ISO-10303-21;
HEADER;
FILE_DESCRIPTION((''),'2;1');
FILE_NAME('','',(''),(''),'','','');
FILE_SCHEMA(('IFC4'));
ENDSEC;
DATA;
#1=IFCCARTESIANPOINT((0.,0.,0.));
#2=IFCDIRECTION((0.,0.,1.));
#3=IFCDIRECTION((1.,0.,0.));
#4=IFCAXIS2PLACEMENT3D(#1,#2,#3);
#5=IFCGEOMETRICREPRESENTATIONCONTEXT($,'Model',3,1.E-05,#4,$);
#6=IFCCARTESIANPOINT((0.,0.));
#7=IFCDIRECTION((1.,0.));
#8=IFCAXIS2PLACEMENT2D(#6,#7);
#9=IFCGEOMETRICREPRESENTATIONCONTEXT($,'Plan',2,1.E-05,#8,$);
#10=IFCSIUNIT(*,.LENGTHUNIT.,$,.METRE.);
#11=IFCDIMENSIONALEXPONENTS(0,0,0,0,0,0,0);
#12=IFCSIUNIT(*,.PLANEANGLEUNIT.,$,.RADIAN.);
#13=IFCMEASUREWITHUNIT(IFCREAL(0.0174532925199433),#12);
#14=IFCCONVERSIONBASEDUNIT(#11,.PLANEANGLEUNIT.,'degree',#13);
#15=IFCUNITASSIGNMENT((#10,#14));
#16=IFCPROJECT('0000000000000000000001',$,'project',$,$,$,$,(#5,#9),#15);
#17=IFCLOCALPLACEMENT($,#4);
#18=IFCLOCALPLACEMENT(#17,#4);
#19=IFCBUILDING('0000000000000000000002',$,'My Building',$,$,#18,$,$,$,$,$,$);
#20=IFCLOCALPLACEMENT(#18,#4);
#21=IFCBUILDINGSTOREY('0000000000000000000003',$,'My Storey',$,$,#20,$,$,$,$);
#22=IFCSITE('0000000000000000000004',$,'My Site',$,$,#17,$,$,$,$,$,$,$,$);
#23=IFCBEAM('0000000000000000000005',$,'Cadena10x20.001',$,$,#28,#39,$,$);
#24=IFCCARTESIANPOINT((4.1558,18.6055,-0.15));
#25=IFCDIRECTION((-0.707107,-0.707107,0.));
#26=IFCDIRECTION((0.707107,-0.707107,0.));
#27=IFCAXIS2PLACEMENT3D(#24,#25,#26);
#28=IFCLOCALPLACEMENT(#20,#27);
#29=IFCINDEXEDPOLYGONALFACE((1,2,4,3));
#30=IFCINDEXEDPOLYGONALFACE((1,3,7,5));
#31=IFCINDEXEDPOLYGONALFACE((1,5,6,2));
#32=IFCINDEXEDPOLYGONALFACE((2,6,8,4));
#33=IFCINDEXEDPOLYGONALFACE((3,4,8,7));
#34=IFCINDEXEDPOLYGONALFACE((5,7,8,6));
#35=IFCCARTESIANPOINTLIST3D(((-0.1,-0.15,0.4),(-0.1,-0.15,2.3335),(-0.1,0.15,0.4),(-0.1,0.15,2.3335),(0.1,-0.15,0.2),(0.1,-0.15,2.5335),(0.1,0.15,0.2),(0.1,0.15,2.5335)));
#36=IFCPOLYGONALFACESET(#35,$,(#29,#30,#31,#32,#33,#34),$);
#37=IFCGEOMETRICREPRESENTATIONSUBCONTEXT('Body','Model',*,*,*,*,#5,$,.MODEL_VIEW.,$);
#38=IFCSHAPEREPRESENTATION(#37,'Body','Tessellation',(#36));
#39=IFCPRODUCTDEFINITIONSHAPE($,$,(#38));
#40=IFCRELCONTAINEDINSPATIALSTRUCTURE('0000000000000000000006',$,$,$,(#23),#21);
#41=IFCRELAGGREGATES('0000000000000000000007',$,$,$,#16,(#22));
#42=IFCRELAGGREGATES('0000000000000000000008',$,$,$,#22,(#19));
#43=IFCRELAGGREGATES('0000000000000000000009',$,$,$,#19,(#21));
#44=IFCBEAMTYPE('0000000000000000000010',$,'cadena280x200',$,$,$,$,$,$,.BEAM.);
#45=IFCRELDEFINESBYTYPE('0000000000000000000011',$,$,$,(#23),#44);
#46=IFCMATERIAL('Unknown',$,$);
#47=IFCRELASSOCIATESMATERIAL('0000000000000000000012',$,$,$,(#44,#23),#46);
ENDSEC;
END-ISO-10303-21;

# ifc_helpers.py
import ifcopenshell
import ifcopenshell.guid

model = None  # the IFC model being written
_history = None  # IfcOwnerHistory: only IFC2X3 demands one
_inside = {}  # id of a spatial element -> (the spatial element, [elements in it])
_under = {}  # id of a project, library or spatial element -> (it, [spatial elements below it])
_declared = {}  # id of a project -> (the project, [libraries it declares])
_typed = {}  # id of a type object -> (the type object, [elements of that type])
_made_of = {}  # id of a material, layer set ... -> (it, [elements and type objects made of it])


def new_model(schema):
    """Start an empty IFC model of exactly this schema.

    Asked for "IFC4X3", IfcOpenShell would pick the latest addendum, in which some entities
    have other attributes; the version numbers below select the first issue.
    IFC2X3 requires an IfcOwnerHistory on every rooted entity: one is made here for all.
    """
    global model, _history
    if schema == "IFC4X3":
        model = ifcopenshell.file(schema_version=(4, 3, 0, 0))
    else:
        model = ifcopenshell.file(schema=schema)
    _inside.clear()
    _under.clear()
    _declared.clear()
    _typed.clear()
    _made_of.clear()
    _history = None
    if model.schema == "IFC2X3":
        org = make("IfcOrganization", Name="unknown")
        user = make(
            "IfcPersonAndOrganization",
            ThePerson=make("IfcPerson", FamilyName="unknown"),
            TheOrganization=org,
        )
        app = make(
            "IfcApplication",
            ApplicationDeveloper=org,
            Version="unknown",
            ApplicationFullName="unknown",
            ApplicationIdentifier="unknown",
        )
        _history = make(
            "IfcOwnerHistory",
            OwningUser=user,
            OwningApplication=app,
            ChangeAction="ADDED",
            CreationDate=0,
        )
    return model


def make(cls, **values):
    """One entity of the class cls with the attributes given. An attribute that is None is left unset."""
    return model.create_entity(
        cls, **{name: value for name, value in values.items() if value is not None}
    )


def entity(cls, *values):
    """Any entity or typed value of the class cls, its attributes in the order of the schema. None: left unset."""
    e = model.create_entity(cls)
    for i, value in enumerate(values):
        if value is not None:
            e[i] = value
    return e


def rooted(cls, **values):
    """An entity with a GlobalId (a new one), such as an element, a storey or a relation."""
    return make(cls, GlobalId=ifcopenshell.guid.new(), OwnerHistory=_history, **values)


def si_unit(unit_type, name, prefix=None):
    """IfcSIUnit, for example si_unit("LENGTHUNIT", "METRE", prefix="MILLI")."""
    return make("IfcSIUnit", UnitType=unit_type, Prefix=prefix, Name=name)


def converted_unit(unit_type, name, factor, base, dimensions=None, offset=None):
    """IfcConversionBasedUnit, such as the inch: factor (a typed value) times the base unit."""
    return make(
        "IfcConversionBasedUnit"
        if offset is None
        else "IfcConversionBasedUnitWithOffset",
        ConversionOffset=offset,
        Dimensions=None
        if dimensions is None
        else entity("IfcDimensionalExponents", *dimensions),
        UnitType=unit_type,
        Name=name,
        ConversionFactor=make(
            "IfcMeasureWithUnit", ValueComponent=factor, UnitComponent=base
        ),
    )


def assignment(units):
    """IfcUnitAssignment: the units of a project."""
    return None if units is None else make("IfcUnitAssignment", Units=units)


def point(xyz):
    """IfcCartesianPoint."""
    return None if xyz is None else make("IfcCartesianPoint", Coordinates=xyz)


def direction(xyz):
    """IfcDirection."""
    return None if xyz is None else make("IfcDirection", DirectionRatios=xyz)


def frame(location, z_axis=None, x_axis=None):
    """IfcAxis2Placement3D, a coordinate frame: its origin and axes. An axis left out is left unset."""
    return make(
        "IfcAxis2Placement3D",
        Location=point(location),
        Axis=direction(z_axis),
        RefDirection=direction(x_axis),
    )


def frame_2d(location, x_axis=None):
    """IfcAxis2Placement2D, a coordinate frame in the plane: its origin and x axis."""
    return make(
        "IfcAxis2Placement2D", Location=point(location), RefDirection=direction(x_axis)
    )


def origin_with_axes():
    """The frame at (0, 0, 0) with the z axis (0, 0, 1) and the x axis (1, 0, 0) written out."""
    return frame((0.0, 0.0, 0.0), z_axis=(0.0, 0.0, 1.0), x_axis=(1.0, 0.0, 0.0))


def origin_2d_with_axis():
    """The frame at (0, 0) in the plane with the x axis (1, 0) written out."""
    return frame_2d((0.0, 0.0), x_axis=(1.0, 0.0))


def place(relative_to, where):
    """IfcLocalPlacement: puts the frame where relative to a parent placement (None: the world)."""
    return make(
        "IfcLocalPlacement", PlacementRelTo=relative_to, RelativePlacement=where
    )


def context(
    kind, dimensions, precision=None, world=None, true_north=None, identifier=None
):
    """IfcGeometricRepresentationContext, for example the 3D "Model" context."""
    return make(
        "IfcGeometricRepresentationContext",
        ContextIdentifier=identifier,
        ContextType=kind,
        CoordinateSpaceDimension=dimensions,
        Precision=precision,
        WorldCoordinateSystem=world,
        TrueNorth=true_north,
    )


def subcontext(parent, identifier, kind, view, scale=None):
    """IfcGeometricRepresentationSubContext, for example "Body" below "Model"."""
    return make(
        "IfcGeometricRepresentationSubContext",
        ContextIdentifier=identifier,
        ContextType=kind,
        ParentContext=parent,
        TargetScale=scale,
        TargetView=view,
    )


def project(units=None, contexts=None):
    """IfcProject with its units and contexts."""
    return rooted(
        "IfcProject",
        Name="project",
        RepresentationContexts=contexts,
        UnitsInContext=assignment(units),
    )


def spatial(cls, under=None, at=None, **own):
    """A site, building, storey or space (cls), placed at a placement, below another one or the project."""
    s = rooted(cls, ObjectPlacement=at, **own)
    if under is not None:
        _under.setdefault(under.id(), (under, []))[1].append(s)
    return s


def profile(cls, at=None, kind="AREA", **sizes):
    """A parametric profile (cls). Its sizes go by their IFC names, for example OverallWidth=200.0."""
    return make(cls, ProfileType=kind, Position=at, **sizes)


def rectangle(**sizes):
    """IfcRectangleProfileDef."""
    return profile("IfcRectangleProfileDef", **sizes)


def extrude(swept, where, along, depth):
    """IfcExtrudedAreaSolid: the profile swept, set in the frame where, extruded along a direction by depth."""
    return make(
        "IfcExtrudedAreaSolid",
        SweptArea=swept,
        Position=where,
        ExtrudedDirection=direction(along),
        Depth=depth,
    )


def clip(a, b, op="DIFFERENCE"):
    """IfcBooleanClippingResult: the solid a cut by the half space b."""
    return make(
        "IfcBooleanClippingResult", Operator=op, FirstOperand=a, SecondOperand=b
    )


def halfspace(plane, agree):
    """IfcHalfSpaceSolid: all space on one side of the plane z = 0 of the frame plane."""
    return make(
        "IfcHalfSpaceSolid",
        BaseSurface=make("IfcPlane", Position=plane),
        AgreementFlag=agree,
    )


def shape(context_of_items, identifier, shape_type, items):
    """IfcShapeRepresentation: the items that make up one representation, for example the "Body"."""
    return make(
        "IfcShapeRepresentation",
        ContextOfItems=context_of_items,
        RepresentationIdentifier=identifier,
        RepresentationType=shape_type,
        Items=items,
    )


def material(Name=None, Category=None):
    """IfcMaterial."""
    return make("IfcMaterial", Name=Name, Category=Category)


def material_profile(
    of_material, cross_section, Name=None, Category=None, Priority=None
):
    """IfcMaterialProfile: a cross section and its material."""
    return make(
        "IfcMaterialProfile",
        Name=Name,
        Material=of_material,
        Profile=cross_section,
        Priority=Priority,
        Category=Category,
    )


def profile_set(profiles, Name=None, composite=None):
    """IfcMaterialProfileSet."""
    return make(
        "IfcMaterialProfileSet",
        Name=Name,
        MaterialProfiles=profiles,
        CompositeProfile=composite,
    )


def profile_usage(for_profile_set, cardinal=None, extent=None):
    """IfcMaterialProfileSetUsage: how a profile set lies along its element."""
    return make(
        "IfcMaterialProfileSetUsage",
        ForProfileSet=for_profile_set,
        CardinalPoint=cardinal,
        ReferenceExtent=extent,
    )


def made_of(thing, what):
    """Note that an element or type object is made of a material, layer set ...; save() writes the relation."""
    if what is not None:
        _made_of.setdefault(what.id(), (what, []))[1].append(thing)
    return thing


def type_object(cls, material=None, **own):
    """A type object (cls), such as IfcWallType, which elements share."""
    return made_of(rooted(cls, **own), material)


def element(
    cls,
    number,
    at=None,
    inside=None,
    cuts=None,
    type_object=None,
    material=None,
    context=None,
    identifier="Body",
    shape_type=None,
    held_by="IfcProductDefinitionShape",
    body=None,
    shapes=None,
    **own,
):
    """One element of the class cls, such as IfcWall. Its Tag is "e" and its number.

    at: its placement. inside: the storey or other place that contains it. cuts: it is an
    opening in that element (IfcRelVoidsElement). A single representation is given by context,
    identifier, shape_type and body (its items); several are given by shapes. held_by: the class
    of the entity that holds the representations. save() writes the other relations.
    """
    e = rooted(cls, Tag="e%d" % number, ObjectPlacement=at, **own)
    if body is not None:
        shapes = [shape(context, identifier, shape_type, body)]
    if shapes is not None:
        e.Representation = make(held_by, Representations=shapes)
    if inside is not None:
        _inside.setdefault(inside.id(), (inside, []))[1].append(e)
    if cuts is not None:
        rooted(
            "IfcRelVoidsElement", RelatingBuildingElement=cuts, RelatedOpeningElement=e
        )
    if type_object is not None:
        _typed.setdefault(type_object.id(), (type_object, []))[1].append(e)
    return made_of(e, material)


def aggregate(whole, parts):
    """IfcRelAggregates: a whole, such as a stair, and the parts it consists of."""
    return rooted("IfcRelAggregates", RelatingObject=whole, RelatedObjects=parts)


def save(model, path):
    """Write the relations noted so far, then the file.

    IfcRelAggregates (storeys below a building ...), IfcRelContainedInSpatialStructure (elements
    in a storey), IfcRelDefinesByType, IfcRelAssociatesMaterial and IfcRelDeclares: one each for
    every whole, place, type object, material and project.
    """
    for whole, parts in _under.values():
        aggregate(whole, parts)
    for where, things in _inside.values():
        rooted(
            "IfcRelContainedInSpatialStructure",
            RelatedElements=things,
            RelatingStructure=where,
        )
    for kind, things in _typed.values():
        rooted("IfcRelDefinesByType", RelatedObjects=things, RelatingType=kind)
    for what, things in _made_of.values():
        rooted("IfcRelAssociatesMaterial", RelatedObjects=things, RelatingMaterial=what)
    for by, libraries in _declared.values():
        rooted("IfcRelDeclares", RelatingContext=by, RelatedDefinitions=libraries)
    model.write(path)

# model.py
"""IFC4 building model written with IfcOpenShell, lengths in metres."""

from ifc_helpers import new_model, entity, si_unit, converted_unit, frame, origin_with_axes, origin_2d_with_axis, place, context, subcontext, project, spatial, rectangle, extrude, clip, halfspace, material, material_profile, profile_set, profile_usage, type_object, element, save


model = new_model("IFC4")

# Units and contexts
model_context = context("Model", 3, precision=1e-05, world=origin_with_axes())
plan_context = context("Plan", 2, precision=1e-05, world=origin_2d_with_axis())
body_context = subcontext(model_context, "Body", "Model", "MODEL_VIEW")
ifc_project = project(units=[si_unit("LENGTHUNIT", "METRE"), converted_unit("PLANEANGLEUNIT", "degree", entity("IfcReal", 0.0174532925199433), si_unit("PLANEANGLEUNIT", "RADIAN"), dimensions=[0, 0, 0, 0, 0, 0, 0])], contexts=[model_context, plan_context])

# Site, building, storey
site_placement = place(None, origin_with_axes())
site = spatial("IfcSite", under=ifc_project, at=site_placement, Name="My Site")
building_placement = place(site_placement, origin_with_axes())
building = spatial("IfcBuilding", under=site, at=building_placement, Name="My Building")
storey_placement = place(building_placement, origin_with_axes())
storey = spatial("IfcBuildingStorey", under=building, at=storey_placement, Name="My Storey")

# Beam
ifc_material_1 = material(Name="Unknown")
ifc_material_profile_1 = material_profile(ifc_material_1, rectangle(XDim=0.2, YDim=0.3))
ifc_profile_set_1 = profile_set([ifc_material_profile_1], Name="concrete")
ifc_profile_usage_1 = profile_usage(ifc_profile_set_1)
beam_type_1 = type_object("IfcBeamType", Name="cadena280x200", PredefinedType="BEAM", material=ifc_profile_set_1)
beam_1_placement = place(storey_placement, frame((4.1558, 18.6055, -0.15), z_axis=(-0.707107, -0.707107, 0.0), x_axis=(0.707107, -0.707107, 0.0)))
element("IfcBeam", 1, at=beam_1_placement, inside=storey, type_object=beam_type_1, material=ifc_profile_usage_1, Name="Cadena10x20.001", context=body_context, shape_type="Clipping", body=[
    clip(clip(extrude(rectangle(XDim=0.2, YDim=0.3), origin_with_axes(), (0.0, 0.0, 1.0), 2.7335), halfspace(frame((-1.0667, 0.29, 1.3667), z_axis=(-0.707107, 0.0, 0.707107), x_axis=(0.707107, 0.0, 0.707107)), False)), halfspace(frame((-1.0667, 0.29, 1.3667), z_axis=(-0.707106, 0.0, -0.707107), x_axis=(0.707107, 0.000001, -0.707106)), False)),
])

save(model, "model.ifc")
